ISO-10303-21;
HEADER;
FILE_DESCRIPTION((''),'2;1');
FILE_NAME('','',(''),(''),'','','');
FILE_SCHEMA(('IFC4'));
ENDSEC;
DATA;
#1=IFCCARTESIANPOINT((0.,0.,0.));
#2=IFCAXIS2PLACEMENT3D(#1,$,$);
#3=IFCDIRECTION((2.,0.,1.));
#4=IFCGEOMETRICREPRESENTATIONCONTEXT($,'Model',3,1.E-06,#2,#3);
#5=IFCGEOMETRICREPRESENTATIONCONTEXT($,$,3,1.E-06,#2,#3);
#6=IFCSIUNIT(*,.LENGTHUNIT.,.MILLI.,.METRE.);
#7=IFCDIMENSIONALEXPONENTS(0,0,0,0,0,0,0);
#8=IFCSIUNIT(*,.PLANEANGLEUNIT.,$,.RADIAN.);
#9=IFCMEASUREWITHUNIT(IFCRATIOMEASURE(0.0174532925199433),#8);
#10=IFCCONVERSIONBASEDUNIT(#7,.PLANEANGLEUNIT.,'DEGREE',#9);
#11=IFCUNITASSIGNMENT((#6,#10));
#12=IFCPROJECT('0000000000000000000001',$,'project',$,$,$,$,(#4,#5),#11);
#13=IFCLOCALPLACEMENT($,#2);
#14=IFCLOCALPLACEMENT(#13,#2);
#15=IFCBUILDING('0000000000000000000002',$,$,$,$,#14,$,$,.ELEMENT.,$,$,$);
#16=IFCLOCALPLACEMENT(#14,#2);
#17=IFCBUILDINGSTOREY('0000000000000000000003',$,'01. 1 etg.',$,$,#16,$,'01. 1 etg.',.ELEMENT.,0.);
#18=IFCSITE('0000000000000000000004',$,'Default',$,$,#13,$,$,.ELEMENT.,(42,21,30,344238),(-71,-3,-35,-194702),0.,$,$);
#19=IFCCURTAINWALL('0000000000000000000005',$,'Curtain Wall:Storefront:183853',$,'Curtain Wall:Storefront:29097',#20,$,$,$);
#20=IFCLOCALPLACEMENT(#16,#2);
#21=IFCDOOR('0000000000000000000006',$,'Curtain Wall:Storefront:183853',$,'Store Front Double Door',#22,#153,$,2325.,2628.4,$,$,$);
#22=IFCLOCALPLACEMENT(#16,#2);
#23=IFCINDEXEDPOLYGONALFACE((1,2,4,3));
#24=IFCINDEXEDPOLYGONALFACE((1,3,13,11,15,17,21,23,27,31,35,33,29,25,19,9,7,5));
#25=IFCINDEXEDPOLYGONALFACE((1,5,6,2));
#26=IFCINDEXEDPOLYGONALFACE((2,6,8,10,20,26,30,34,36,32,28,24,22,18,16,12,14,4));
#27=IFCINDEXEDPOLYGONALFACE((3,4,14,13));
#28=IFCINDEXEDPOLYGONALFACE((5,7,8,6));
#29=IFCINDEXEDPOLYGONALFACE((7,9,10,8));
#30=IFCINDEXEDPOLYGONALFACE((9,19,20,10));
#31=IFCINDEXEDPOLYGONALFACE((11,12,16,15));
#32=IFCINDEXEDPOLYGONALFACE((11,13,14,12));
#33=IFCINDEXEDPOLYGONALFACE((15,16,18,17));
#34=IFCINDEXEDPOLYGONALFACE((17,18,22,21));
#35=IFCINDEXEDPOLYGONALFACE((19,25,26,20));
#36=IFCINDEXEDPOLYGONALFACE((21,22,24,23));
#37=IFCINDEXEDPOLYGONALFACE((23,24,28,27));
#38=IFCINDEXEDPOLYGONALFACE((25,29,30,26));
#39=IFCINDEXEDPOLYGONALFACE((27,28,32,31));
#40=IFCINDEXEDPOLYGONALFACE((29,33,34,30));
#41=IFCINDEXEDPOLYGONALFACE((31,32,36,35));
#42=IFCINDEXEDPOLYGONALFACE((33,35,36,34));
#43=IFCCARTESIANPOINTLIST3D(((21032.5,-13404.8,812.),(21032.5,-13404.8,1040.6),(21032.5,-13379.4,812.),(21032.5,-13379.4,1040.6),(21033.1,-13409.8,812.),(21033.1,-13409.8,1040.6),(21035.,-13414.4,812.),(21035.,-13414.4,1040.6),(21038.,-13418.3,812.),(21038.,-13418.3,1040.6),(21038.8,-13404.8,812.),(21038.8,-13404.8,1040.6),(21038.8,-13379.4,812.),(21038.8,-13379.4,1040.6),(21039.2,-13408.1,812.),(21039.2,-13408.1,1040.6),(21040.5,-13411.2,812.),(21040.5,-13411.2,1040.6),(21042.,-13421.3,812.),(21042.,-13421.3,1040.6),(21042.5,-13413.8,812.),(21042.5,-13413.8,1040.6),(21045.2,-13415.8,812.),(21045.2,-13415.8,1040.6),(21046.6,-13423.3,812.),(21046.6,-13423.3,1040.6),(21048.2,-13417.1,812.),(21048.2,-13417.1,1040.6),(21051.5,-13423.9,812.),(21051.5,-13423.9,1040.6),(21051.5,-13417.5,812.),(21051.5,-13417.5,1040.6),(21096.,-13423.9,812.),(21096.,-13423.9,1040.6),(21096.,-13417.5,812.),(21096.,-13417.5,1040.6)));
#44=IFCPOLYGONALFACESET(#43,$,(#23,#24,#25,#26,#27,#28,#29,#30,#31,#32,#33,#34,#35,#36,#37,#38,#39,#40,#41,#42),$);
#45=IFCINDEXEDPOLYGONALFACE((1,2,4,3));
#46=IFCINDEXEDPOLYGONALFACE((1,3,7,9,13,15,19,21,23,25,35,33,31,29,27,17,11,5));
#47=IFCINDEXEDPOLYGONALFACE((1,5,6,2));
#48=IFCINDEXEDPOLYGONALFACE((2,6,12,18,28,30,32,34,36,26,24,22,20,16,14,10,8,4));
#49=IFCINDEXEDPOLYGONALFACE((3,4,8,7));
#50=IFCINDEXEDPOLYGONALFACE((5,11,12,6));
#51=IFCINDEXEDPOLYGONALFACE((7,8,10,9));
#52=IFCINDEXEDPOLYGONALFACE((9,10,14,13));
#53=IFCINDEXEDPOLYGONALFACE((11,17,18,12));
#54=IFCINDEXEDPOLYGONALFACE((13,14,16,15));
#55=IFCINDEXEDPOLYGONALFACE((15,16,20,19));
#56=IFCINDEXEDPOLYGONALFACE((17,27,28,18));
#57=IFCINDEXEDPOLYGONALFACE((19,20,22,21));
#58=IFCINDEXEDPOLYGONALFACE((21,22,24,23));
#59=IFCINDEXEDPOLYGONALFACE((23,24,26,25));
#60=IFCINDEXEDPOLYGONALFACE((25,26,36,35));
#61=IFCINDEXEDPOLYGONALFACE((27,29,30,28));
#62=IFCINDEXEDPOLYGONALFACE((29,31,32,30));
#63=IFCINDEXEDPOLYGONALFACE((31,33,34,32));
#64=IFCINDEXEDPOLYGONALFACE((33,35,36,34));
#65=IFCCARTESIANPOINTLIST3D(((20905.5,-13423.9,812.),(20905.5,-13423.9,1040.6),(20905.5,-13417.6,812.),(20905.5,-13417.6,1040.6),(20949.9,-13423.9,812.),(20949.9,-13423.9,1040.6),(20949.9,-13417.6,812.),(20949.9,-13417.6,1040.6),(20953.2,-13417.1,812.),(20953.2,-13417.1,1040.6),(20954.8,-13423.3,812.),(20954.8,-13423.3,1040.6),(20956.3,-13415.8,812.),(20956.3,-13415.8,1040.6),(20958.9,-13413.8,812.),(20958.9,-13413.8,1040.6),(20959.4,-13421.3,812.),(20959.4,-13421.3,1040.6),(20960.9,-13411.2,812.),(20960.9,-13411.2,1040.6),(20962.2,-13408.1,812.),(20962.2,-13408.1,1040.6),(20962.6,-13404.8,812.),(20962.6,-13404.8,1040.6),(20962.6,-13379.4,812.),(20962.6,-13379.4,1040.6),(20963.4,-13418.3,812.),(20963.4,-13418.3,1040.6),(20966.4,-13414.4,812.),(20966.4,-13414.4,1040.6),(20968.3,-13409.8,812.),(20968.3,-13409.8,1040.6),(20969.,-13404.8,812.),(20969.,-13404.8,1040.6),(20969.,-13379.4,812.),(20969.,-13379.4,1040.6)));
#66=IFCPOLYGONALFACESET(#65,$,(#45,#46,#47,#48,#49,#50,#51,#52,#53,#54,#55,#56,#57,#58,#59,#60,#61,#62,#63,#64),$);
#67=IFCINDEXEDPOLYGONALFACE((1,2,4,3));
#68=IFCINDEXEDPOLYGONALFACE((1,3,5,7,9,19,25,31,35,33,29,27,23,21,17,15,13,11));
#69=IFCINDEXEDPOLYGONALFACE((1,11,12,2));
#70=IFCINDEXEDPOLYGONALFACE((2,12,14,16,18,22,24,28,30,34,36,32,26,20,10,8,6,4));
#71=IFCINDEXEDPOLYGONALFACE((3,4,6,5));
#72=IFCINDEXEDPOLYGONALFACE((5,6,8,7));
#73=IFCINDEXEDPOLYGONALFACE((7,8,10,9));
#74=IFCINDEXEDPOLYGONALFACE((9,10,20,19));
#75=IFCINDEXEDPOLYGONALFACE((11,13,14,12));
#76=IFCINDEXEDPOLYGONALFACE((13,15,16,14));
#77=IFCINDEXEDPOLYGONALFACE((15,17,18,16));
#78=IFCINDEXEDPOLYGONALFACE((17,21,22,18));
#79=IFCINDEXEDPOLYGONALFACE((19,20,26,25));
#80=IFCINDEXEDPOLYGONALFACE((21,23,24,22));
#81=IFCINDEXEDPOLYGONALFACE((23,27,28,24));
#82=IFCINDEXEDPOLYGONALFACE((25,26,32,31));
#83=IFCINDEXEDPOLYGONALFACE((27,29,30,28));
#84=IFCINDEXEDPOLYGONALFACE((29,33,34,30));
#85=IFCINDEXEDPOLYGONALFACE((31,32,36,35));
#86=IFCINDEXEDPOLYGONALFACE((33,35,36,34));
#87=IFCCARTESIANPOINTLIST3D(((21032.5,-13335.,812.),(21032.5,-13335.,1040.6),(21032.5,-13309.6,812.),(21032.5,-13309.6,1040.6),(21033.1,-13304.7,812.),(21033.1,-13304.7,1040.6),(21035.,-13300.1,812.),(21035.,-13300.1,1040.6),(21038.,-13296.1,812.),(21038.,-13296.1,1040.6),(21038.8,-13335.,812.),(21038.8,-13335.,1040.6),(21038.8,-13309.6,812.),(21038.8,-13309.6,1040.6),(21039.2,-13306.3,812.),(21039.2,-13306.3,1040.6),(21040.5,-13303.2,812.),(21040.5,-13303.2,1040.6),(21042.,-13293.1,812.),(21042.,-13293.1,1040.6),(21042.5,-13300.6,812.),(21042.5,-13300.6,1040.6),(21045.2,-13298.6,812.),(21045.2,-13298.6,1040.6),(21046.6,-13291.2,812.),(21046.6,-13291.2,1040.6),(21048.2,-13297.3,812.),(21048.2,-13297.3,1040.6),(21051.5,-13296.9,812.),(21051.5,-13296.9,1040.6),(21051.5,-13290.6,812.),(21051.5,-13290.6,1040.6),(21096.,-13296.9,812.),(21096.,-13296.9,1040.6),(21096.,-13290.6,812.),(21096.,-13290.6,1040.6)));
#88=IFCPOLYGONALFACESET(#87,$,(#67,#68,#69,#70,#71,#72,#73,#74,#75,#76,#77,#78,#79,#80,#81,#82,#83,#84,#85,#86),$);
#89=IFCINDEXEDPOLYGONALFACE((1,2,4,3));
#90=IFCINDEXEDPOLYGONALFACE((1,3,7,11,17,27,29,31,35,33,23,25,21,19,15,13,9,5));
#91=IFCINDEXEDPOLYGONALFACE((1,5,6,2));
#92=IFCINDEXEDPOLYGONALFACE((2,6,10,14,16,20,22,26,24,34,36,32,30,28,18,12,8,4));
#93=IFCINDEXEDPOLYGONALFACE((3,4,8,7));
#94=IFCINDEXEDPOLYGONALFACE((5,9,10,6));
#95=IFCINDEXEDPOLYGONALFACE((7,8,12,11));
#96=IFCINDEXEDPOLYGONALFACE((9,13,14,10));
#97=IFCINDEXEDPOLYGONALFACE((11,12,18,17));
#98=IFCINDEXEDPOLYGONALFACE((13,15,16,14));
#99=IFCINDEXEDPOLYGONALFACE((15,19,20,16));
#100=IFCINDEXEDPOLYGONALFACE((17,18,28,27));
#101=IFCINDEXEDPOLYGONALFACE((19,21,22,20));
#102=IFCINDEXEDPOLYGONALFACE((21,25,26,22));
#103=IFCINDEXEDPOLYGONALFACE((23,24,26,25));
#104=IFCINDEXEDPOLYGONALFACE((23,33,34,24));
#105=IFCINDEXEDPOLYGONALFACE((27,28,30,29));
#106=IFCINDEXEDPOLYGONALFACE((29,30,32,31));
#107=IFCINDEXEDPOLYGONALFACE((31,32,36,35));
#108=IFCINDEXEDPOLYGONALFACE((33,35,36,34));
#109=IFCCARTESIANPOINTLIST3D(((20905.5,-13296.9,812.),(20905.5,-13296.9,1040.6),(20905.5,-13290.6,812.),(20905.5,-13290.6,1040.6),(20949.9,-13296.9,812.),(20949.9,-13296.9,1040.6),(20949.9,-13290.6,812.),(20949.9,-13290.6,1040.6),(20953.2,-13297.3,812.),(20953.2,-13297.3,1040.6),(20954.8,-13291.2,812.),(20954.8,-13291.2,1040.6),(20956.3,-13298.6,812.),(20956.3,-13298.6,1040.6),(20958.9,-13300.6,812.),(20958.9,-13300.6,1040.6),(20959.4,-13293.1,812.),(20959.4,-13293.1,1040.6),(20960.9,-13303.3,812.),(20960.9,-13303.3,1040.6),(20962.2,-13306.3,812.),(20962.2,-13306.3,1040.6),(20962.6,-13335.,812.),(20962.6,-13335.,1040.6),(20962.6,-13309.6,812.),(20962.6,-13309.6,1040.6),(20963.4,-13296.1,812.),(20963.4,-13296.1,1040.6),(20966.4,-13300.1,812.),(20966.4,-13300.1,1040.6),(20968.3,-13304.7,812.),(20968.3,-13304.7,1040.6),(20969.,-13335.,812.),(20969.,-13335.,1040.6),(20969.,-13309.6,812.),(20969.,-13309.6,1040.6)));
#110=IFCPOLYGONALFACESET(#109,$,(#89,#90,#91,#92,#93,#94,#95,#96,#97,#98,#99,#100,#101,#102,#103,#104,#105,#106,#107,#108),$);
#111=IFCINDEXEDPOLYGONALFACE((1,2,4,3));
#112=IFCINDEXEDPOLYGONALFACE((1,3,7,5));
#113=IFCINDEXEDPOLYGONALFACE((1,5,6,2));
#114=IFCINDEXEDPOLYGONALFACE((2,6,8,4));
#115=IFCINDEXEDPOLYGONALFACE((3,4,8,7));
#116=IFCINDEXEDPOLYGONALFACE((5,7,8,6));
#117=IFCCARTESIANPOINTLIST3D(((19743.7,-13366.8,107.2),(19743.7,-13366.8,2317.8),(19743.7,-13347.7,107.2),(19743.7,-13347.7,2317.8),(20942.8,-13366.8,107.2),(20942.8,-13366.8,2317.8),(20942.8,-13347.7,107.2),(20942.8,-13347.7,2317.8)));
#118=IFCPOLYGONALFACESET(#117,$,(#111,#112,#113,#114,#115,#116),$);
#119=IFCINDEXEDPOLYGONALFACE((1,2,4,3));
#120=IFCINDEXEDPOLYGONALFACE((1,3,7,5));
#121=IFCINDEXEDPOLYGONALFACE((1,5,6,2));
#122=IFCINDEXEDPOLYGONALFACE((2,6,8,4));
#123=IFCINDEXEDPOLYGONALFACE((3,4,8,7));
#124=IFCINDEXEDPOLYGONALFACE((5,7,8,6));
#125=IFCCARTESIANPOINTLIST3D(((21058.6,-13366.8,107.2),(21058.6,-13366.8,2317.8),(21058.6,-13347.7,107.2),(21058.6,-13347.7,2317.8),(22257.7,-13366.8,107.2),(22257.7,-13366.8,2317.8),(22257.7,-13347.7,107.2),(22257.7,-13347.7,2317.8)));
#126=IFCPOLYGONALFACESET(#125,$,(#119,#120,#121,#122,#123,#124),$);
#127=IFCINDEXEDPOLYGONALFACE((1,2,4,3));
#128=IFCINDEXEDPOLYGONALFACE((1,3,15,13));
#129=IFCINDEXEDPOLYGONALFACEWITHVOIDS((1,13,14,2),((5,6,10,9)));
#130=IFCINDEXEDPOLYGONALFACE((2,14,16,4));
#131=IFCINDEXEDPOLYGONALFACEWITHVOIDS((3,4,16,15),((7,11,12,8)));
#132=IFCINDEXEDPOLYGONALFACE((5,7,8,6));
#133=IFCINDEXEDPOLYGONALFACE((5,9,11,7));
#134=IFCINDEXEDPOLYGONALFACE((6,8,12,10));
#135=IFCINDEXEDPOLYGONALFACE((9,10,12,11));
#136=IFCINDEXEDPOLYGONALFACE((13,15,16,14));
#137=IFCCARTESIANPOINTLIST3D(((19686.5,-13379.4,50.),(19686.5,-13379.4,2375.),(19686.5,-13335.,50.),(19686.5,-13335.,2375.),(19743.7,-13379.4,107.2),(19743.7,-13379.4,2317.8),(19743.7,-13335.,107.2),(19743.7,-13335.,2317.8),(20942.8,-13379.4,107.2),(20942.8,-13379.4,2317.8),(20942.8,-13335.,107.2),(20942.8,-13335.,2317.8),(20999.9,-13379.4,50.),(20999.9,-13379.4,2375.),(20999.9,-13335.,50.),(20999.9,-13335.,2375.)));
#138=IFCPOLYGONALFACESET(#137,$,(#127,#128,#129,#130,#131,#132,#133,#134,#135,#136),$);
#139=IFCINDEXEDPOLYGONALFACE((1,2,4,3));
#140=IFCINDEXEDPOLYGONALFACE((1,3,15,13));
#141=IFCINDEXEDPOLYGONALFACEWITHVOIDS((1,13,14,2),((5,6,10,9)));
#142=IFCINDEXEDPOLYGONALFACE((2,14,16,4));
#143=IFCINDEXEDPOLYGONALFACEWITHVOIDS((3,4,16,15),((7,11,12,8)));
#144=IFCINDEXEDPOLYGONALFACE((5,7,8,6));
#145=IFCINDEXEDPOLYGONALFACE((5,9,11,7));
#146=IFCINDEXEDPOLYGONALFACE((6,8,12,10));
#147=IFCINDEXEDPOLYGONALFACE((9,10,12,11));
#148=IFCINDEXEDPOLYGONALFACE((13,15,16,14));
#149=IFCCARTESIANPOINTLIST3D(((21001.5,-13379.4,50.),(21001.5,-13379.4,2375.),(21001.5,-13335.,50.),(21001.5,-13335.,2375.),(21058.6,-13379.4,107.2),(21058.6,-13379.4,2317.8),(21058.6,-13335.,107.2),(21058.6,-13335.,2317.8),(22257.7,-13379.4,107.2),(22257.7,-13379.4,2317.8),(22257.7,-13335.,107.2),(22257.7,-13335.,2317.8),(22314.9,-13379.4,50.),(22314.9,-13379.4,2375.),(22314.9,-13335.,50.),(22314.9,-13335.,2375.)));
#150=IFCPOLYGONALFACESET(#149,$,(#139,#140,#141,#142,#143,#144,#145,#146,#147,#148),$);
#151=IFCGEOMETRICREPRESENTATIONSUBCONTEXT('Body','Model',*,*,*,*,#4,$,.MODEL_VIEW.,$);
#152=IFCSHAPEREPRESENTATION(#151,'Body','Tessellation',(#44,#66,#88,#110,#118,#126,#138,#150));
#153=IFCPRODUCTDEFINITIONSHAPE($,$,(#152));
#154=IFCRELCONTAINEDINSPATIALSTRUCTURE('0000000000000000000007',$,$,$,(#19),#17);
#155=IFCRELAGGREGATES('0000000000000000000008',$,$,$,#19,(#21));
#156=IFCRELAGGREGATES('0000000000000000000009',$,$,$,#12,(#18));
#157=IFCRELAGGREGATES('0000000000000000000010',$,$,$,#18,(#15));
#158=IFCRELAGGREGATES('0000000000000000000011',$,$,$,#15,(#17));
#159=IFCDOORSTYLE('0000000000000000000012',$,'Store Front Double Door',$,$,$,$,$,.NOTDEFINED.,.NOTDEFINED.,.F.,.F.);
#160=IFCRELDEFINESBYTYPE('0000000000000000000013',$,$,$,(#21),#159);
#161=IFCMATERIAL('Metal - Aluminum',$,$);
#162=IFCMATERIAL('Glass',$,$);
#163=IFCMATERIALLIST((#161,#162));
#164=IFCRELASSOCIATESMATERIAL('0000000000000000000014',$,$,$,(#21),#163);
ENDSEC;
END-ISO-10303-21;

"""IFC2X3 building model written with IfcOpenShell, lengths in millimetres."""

from ifc_helpers import new_model, entity, si_unit, converted_unit, direction, frame, frame_2d, origin, place, context, subcontext, project, spatial, polyline, circle_curve, parameter, trimmed, segment, composite_curve, rectangle, outline, extrude, source, transform, mapped, material, material_list, type_object, type_shapes, element, aggregate, save


model = new_model("IFC2X3")

# Units and contexts
model_context = context("Model", 3, precision=1e-06, world=origin(), true_north=direction((2.0, 0.0, 1.0)))
context_of_model = context(None, 3, precision=1e-06, world=origin(), true_north=direction((2.0, 0.0, 1.0)))
body_context = subcontext(model_context, "Body", "Model", "MODEL_VIEW")
ifc_project = project(units=[si_unit("LENGTHUNIT", "METRE", prefix="MILLI"), converted_unit("PLANEANGLEUNIT", "DEGREE", entity("IfcRatioMeasure", 0.0174532925199433), si_unit("PLANEANGLEUNIT", "RADIAN"), dimensions=[0, 0, 0, 0, 0, 0, 0])], contexts=[model_context, context_of_model])

# Site, building, storey
site_placement = place(None, origin())
site = spatial("IfcSite", under=ifc_project, at=site_placement, Name="Default", CompositionType="ELEMENT", RefLatitude=(42, 21, 30, 344238), RefLongitude=(-71, -3, -35, -194702), RefElevation=0.0)
building_placement = place(site_placement, origin())
building = spatial("IfcBuilding", under=site, at=building_placement, CompositionType="ELEMENT")
storey_placement = place(building_placement, origin())
storey = spatial("IfcBuildingStorey", under=building, at=storey_placement, Name="01. 1 etg.", LongName="01. 1 etg.", CompositionType="ELEMENT", Elevation=0.0)

# Curtain wall
curtain_wall_placement = place(storey_placement, origin())
curtain_wall = element("IfcCurtainWall", 1, at=curtain_wall_placement, inside=storey, Name="Curtain Wall:Storefront:183853", ObjectType="Curtain Wall:Storefront:29097")
ifc_material_1 = material(Name="Glass")

# Door
ifc_material_2 = material(Name="Metal - Aluminum")
ifc_material_list_1 = material_list([ifc_material_2, ifc_material_1])
door_style_1 = type_object("IfcDoorStyle", Name="Store Front Double Door", ConstructionType="NOTDEFINED", OperationType="NOTDEFINED", ParameterTakesPrecedence=False, Sizeable=False)
shared_shape_1 = source(origin(), body_context, "Body", "SweptSolid", [
    extrude(outline(composite_curve([segment(trimmed(circle_curve(frame_2d((-3.2, 1.6), x_axis=(1.0, 0.0)), 19.0), [parameter(180.0)], [parameter(270.0)], True, "PARAMETER"), True, "CONTINUOUS"), segment(polyline([(-3.2, -17.5), (41.3, -17.5)]), True, "CONTINUOUS"), segment(polyline([(41.3, -17.5), (41.3, -11.1)]), True, "CONTINUOUS"), segment(polyline([(41.3, -11.1), (-3.2, -11.1)]), True, "CONTINUOUS"), segment(trimmed(circle_curve(frame_2d((-3.2, 1.6), x_axis=(1.0, 0.0)), 12.7), [parameter(180.0)], [parameter(270.0)], True, "PARAMETER"), False, "CONTINUOUS"), segment(polyline([(-15.9, 1.6), (-15.9, 27.0)]), True, "CONTINUOUS"), segment(polyline([(-15.9, 27.0), (-22.2, 27.0)]), True, "CONTINUOUS"), segment(polyline([(-22.2, 27.0), (-22.2, 1.6)]), True, "CONTINUOUS")], self_intersect=False)), frame((54.0, -16.4, 762.0)), (0.0, 0.0, 1.0), 228.6),
    extrude(outline(composite_curve([segment(polyline([(1.6, -22.2), (27.0, -22.2)]), True, "CONTINUOUS"), segment(polyline([(27.0, -22.2), (27.0, -15.9)]), True, "CONTINUOUS"), segment(polyline([(27.0, -15.9), (1.6, -15.9)]), True, "CONTINUOUS"), segment(trimmed(circle_curve(frame_2d((1.6, -3.2), x_axis=(0.0, -1.0)), 12.7), [parameter(270.0)], [parameter(0.0)], True, "PARAMETER"), False, "CONTINUOUS"), segment(polyline([(-11.1, -3.2), (-11.1, 41.3)]), True, "CONTINUOUS"), segment(polyline([(-11.1, 41.3), (-17.5, 41.3)]), True, "CONTINUOUS"), segment(polyline([(-17.5, 41.3), (-17.5, -3.2)]), True, "CONTINUOUS"), segment(trimmed(circle_curve(frame_2d((1.6, -3.2), x_axis=(0.0, -1.0)), 19.1), [parameter(270.0)], [parameter(360.0)], True, "PARAMETER"), True, "CONTINUOUS")], self_intersect=False)), frame((-54.0, -16.4, 762.0), z_axis=(0.0, 0.0, 1.0), x_axis=(0.0, 1.0, 0.0)), (0.0, 0.0, 1.0), 228.6),
    extrude(outline(composite_curve([segment(polyline([(1.6, -22.2), (27.0, -22.2)]), True, "CONTINUOUS"), segment(polyline([(27.0, -22.2), (27.0, -15.9)]), True, "CONTINUOUS"), segment(polyline([(27.0, -15.9), (1.6, -15.9)]), True, "CONTINUOUS"), segment(trimmed(circle_curve(frame_2d((1.6, -3.2), x_axis=(0.0, 1.0)), 12.7), [parameter(90.0)], [parameter(180.0)], True, "PARAMETER"), False, "CONTINUOUS"), segment(polyline([(-11.1, -3.2), (-11.1, 41.3)]), True, "CONTINUOUS"), segment(polyline([(-11.1, 41.3), (-17.5, 41.3)]), True, "CONTINUOUS"), segment(polyline([(-17.5, 41.3), (-17.5, -3.2)]), True, "CONTINUOUS"), segment(trimmed(circle_curve(frame_2d((1.6, -3.2), x_axis=(0.0, 1.0)), 19.1), [parameter(90.0)], [parameter(180.0)], True, "PARAMETER"), True, "CONTINUOUS")], self_intersect=False)), frame((54.0, 82.0, 762.0), z_axis=(0.0, 0.0, 1.0), x_axis=(0.0, -1.0, 0.0)), (0.0, 0.0, 1.0), 228.6),
    extrude(outline(composite_curve([segment(trimmed(circle_curve(frame_2d((3.2, -1.6), x_axis=(1.0, 0.0)), 19.0), [parameter(0.0)], [parameter(90.0)], True, "PARAMETER"), True, "CONTINUOUS"), segment(polyline([(3.2, 17.5), (-41.3, 17.5)]), True, "CONTINUOUS"), segment(polyline([(-41.3, 17.5), (-41.3, 11.1)]), True, "CONTINUOUS"), segment(polyline([(-41.3, 11.1), (3.2, 11.1)]), True, "CONTINUOUS"), segment(trimmed(circle_curve(frame_2d((3.2, -1.6), x_axis=(1.0, 0.0)), 12.7), [parameter(0.0)], [parameter(90.0)], True, "PARAMETER"), False, "CONTINUOUS"), segment(polyline([(15.9, -1.6), (15.9, -27.0)]), True, "CONTINUOUS"), segment(polyline([(15.9, -27.0), (22.2, -27.0)]), True, "CONTINUOUS"), segment(polyline([(22.2, -27.0), (22.2, -1.6)]), True, "CONTINUOUS")], self_intersect=False)), frame((-54.0, 82.0, 762.0)), (0.0, 0.0, 1.0), 228.6),
    extrude(rectangle(XDim=19.0, YDim=1199.1, at=frame_2d((0.0, 0.0), x_axis=(1.0, 0.0))), frame((-657.5, 32.8, 57.1), z_axis=(0.0, 0.0, 1.0), x_axis=(0.0, 1.0, 0.0)), (0.0, 0.0, 1.0), 2210.7),
    extrude(rectangle(XDim=19.0, YDim=1199.1, at=frame_2d((0.0, 0.0), x_axis=(1.0, 0.0))), frame((657.5, 32.8, 57.1), z_axis=(0.0, 0.0, 1.0), x_axis=(0.0, 1.0, 0.0)), (0.0, 0.0, 1.0), 2210.7),
    extrude(outline(polyline([(-1162.5, -656.7), (1162.5, -656.7), (1162.5, 656.7), (-1162.5, 656.7), (-1162.5, -656.7)]), holes=[polyline([(-1105.3, 599.5), (1105.3, 599.5), (1105.3, -599.5), (-1105.3, -599.5), (-1105.3, 599.5)])]), frame((-657.5, 10.5, 1162.5), z_axis=(0.0, 1.0, 0.0), x_axis=(0.0, 0.0, -1.0)), (0.0, 0.0, 1.0), 44.5),
    extrude(outline(polyline([(-656.7, -1162.5), (656.7, -1162.5), (656.7, 1162.5), (-656.7, 1162.5), (-656.7, -1162.5)]), holes=[polyline([(-599.5, -1105.3), (-599.5, 1105.3), (599.5, 1105.3), (599.5, -1105.3), (-599.5, -1105.3)])]), frame((657.5, 10.5, 1162.5), z_axis=(0.0, 1.0, 0.0), x_axis=(1.0, 0.0, 0.0)), (0.0, 0.0, 1.0), 44.5),
])
type_shapes(door_style_1, [shared_shape_1])
door_1_placement = place(storey_placement, frame((21000.7, -13390.0, 50.0)))
door_1 = element("IfcDoor", 2, at=door_1_placement, type_object=door_style_1, material=ifc_material_list_1, Name="Curtain Wall:Storefront:183853", ObjectType="Store Front Double Door", OverallHeight=2325.0, OverallWidth=2628.4, context=body_context, shape_type="MappedRepresentation", body=[
    mapped(shared_shape_1, transform((0.0, 0.0, 0.0), scale=1.0)),
])
aggregate(curtain_wall, [door_1])

save(model, "model.ifc")
